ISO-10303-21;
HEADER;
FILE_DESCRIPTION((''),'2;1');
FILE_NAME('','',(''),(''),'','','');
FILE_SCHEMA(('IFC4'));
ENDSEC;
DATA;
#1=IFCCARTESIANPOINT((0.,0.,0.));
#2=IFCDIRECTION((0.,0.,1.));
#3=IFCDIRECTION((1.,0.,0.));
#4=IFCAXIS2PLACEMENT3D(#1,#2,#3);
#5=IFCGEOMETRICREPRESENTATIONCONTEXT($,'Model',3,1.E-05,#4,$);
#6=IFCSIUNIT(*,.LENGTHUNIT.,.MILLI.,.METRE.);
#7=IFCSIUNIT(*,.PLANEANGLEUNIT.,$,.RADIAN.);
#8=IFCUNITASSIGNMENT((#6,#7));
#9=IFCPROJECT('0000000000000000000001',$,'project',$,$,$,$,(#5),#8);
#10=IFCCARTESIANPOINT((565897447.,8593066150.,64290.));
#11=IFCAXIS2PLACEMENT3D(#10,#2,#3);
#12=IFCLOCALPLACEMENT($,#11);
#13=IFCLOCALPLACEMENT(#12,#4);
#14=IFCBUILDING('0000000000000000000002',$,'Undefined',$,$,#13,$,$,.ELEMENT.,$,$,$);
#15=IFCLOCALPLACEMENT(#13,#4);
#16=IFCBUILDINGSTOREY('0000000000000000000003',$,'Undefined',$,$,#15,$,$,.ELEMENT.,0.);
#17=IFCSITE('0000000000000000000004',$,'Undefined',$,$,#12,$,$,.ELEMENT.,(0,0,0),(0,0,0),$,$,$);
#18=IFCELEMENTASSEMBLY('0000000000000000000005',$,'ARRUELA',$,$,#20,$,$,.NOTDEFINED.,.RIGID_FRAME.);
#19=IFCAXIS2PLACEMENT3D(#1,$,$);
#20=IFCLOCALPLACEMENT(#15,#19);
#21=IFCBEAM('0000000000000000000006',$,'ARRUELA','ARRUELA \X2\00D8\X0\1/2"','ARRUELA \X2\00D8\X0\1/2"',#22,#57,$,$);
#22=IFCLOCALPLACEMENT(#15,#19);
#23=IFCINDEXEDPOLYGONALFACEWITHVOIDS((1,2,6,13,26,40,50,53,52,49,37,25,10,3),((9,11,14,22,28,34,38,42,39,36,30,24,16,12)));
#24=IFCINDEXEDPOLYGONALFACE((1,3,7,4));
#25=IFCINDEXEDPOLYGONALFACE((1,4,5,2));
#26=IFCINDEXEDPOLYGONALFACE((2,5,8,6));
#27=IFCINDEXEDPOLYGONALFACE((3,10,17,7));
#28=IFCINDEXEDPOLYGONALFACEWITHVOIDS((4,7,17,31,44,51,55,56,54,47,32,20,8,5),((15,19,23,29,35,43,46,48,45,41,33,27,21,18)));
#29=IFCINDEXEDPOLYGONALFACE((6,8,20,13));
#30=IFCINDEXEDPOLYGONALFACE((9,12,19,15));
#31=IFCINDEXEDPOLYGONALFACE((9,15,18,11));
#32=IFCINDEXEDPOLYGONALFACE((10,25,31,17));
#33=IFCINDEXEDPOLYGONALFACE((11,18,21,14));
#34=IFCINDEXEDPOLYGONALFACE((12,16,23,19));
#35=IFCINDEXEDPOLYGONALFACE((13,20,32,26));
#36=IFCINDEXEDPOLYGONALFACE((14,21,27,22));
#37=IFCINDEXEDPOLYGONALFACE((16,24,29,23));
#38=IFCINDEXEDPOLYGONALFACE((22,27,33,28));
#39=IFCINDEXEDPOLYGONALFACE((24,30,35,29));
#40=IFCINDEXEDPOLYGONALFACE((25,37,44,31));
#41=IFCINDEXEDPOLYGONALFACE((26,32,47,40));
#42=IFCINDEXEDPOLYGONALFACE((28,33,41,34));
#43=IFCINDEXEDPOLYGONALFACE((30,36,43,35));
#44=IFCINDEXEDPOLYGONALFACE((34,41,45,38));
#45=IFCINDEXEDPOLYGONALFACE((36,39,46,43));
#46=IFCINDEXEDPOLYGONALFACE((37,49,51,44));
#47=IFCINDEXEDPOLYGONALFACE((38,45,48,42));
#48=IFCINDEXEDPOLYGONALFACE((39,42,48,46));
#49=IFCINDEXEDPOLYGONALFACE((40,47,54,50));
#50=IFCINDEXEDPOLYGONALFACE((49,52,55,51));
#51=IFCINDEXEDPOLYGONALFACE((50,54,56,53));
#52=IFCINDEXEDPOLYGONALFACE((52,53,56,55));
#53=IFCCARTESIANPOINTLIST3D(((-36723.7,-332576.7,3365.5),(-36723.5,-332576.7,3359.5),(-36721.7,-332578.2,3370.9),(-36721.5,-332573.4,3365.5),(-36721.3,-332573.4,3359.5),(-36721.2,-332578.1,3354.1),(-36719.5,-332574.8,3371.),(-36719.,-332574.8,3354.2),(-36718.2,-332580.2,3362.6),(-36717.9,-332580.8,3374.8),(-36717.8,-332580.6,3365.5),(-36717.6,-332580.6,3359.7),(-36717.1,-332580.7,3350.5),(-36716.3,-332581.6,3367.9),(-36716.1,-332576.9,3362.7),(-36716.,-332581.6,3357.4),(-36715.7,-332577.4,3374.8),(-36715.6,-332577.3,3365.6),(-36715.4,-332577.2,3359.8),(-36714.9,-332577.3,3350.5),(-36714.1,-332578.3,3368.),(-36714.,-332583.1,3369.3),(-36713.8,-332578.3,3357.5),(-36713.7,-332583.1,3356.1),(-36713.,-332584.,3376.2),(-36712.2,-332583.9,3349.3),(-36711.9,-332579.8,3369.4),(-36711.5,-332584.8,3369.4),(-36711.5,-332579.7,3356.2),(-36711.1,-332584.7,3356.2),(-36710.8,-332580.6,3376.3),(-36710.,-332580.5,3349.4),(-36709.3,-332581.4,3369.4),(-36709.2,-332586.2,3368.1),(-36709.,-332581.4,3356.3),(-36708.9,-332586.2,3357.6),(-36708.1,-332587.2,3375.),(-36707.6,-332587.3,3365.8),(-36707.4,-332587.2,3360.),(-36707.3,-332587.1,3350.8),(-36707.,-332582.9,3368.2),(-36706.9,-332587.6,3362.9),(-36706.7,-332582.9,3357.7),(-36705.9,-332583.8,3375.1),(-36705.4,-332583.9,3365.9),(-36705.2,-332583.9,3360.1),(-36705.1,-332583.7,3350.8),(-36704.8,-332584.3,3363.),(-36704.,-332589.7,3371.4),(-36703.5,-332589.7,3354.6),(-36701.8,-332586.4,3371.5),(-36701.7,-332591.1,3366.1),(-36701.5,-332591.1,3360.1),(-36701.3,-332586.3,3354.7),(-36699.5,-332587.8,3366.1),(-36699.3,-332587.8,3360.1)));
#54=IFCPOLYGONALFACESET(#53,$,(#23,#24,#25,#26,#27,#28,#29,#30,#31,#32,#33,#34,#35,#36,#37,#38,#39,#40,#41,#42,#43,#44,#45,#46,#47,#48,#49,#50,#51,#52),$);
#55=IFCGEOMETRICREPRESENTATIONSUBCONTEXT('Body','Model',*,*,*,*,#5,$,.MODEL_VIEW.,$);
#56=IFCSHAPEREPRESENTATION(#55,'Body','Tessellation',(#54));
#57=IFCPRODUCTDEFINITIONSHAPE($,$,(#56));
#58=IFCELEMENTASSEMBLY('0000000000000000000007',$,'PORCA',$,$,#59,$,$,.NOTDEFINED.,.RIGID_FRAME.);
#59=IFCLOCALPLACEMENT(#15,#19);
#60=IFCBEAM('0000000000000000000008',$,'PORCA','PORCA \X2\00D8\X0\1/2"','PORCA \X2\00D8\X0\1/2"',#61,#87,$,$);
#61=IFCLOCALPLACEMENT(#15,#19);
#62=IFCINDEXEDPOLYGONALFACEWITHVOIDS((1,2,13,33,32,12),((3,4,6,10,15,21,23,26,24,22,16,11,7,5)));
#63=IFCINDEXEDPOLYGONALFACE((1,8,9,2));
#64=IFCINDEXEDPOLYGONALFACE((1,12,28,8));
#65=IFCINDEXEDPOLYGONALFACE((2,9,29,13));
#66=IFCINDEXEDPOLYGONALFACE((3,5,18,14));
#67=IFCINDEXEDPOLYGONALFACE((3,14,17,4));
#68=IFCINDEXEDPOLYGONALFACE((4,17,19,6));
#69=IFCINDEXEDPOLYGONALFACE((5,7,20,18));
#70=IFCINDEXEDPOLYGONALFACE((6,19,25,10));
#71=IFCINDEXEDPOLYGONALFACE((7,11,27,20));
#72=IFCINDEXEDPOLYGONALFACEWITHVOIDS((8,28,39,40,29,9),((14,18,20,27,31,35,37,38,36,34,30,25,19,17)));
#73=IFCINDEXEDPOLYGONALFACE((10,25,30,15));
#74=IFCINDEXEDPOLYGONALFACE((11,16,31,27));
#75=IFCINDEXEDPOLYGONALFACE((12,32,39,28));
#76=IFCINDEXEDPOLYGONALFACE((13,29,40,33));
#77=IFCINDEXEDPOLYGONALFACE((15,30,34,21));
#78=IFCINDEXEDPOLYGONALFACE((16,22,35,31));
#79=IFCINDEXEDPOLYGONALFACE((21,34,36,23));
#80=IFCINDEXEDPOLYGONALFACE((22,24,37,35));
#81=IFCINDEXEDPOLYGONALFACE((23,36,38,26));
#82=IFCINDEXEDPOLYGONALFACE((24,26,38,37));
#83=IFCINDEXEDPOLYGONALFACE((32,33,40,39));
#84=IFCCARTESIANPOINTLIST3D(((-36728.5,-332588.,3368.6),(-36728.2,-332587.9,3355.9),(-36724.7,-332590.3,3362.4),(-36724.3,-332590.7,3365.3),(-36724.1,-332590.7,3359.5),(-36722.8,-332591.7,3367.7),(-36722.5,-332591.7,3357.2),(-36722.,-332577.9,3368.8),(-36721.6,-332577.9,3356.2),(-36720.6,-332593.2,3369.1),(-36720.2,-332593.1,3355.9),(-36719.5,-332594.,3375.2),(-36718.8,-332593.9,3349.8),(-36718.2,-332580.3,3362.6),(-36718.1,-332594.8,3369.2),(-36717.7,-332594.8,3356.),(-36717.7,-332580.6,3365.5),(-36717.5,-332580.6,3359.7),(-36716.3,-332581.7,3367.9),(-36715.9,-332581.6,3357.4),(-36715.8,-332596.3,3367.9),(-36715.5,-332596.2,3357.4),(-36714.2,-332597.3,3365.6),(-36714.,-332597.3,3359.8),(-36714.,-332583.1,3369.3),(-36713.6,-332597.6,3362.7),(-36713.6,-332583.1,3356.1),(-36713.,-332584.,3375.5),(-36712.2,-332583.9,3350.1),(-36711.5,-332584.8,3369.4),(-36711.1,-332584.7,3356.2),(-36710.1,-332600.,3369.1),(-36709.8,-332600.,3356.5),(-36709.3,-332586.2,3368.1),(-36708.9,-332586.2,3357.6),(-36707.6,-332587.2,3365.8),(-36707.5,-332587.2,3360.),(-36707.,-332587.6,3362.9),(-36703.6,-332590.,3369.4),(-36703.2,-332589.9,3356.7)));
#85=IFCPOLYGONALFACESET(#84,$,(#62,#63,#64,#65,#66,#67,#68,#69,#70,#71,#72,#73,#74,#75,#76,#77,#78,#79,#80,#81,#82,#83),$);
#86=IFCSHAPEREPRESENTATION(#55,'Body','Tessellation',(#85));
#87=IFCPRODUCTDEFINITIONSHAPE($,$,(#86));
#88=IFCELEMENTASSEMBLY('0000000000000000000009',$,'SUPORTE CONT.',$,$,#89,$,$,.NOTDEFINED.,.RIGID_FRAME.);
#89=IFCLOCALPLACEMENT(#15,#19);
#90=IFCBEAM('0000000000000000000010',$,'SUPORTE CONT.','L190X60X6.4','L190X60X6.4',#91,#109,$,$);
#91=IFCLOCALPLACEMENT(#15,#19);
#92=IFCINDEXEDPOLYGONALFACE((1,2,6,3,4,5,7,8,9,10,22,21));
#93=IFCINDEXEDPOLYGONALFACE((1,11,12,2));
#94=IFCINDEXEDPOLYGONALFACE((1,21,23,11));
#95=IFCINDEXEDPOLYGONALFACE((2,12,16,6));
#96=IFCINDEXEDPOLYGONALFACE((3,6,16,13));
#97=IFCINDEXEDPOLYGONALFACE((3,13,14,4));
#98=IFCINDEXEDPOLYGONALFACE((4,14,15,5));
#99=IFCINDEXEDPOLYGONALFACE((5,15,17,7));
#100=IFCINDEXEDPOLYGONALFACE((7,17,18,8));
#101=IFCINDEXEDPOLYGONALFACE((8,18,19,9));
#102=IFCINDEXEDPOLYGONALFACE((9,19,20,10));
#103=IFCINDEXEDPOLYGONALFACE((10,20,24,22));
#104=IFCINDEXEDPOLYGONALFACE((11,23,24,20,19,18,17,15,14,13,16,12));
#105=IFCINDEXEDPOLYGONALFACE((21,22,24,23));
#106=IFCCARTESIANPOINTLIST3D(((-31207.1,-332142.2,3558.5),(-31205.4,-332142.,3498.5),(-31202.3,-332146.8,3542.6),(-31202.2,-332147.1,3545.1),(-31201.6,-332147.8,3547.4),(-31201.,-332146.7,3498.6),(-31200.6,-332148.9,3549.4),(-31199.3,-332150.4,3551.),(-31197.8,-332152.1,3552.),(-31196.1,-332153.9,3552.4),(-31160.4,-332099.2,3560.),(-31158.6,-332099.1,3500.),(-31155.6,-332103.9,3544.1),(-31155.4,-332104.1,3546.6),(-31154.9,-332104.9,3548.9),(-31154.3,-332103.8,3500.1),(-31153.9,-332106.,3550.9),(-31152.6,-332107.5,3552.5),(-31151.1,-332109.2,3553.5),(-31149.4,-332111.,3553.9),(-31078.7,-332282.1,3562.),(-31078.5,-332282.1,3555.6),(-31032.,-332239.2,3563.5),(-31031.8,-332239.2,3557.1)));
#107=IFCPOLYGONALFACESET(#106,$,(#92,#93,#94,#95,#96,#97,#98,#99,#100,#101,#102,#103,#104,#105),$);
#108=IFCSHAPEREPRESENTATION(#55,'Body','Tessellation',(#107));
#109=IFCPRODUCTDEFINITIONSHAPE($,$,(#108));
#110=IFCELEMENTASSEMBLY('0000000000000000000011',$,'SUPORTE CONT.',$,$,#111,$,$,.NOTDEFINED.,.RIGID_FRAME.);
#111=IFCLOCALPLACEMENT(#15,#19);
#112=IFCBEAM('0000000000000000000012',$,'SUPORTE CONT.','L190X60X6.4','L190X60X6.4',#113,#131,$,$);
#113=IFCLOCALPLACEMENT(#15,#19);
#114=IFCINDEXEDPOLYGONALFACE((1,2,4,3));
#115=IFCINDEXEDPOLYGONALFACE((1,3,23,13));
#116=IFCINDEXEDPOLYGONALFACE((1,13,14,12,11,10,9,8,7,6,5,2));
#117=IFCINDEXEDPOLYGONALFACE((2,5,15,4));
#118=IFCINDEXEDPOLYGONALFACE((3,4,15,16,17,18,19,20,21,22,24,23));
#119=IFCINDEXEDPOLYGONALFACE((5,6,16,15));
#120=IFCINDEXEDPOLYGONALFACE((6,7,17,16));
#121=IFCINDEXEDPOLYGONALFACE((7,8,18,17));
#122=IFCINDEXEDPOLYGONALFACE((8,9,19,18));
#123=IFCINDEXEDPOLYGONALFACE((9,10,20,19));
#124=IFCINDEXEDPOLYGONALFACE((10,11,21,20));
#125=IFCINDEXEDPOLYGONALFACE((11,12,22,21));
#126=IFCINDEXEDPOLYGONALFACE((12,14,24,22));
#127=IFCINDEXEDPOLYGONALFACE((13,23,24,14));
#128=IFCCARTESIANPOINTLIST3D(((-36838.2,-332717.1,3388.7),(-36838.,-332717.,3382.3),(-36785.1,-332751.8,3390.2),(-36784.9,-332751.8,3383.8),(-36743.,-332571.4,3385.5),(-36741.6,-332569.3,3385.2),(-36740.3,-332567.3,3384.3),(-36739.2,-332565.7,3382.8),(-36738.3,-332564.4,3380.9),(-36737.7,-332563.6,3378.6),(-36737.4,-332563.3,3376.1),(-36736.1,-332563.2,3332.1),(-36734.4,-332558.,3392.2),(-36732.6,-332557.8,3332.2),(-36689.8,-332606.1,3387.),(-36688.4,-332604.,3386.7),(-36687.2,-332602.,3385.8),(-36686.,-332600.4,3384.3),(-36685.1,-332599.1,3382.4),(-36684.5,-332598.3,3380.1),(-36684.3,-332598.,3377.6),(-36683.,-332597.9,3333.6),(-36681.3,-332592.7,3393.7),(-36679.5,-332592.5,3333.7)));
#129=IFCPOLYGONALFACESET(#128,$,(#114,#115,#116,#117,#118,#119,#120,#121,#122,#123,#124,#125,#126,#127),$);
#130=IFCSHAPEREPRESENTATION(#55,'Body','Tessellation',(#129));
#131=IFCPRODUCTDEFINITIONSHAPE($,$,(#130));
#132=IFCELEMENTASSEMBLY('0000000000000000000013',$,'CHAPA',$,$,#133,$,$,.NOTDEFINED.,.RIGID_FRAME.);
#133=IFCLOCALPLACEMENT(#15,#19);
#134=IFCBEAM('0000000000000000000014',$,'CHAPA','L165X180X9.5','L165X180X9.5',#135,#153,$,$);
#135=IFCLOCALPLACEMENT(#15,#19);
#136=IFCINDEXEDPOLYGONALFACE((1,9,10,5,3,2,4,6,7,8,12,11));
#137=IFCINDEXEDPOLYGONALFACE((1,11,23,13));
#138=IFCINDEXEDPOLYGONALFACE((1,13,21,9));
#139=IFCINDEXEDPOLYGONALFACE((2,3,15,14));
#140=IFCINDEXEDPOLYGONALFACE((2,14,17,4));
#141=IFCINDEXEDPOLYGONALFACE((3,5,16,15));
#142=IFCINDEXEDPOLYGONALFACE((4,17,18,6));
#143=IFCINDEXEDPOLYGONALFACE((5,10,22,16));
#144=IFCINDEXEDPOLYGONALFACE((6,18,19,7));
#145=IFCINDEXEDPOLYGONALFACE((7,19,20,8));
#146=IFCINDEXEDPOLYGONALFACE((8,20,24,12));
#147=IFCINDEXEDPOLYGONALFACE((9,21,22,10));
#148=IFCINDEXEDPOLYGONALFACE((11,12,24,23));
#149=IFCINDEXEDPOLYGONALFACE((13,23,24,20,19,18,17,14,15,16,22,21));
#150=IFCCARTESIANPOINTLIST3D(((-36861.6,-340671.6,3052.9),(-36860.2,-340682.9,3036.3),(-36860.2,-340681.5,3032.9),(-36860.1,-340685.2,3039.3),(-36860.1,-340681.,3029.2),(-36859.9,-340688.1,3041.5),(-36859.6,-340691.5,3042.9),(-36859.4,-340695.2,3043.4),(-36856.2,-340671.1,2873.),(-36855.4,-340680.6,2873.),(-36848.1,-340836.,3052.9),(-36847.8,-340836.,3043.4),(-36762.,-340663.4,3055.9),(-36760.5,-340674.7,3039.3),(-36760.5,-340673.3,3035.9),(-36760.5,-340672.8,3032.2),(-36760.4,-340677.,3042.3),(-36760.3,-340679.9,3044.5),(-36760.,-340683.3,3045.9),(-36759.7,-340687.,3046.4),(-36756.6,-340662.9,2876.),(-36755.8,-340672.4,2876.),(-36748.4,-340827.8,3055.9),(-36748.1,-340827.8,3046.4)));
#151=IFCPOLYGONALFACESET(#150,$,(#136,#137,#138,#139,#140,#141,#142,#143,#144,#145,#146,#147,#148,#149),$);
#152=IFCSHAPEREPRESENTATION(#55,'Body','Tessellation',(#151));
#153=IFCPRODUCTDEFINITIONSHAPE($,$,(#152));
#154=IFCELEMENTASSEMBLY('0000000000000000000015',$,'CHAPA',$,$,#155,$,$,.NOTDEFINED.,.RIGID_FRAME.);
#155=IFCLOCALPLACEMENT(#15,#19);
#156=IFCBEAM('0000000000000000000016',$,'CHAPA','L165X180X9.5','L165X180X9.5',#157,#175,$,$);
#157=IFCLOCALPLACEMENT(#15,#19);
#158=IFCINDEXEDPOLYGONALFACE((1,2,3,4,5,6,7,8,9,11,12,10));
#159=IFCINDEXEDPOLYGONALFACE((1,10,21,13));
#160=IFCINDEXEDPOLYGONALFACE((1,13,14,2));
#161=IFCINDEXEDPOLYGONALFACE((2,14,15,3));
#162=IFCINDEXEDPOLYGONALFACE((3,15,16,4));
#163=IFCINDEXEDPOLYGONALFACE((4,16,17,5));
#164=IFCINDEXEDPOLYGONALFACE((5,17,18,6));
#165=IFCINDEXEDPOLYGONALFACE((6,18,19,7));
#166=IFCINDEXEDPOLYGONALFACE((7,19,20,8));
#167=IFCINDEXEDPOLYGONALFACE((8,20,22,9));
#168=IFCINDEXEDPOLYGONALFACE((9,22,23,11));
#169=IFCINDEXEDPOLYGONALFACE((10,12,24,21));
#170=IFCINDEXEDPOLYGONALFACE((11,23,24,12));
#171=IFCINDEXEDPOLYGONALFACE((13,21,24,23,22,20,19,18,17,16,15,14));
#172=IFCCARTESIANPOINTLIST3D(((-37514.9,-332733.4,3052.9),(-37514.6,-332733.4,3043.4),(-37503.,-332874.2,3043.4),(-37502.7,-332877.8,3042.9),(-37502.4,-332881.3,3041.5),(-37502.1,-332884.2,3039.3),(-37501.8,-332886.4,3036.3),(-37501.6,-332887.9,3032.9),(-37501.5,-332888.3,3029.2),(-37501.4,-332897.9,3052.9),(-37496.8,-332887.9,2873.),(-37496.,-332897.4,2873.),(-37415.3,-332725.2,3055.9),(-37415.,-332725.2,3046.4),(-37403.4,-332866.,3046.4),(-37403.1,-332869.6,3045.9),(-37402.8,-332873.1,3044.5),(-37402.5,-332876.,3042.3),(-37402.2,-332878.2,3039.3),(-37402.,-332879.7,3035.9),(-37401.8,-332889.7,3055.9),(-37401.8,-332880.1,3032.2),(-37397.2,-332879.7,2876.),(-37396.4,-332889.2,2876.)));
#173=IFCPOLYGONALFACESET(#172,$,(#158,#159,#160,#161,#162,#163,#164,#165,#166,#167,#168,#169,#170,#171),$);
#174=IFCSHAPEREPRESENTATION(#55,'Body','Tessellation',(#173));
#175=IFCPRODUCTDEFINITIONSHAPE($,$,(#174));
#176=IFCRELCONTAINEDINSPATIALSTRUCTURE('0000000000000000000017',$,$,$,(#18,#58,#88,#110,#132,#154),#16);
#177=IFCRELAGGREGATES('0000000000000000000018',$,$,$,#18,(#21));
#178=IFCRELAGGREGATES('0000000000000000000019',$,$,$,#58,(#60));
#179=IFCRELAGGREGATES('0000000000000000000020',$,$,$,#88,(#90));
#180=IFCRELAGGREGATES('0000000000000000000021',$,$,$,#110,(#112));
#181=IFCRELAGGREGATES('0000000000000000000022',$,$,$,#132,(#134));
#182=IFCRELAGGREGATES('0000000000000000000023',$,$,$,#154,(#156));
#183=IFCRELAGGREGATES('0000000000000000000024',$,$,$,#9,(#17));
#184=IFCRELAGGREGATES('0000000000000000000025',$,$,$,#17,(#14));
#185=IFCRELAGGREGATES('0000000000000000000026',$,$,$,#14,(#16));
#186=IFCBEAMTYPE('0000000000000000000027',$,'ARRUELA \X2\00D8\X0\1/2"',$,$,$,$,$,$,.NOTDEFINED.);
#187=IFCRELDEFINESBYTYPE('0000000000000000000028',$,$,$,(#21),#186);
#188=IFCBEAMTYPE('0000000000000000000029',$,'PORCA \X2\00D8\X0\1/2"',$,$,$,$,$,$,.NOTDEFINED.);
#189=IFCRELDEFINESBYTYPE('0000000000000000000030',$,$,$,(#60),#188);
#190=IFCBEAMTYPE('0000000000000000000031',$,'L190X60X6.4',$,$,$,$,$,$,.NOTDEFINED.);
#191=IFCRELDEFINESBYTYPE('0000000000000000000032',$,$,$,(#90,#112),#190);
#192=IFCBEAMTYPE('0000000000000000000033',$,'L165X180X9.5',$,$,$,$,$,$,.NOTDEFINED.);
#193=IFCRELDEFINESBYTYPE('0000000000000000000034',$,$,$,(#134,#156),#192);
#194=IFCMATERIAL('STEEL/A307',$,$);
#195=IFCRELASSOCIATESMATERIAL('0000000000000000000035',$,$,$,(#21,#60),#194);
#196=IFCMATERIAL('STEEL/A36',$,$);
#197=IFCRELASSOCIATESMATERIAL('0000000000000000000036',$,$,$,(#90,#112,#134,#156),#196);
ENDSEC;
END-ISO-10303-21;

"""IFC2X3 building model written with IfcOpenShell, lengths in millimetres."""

from ifc_helpers import new_model, si_unit, frame, origin_with_axes, origin_2d_with_axis, place, context, subcontext, project, spatial, polyline, l_section, outline, extrude, material, type_object, element, aggregate, save


model = new_model("IFC2X3")

# Units and contexts
model_context = context("Model", 3, precision=1e-05, world=origin_with_axes())
body_context = subcontext(model_context, "Body", "Model", "MODEL_VIEW")
ifc_project = project(units=[si_unit("LENGTHUNIT", "METRE", prefix="MILLI"), si_unit("PLANEANGLEUNIT", "RADIAN")], contexts=[model_context])

# Site, building, storey
site_placement = place(None, frame((565897447.0, 8593066150.0, 64290.0), z_axis=(0.0, 0.0, 1.0), x_axis=(1.0, 0.0, 0.0)))
site = spatial("IfcSite", under=ifc_project, at=site_placement, Name="Undefined", CompositionType="ELEMENT", RefLatitude=(0, 0, 0), RefLongitude=(0, 0, 0))
building_placement = place(site_placement, origin_with_axes())
building = spatial("IfcBuilding", under=site, at=building_placement, Name="Undefined", CompositionType="ELEMENT")
storey_placement = place(building_placement, origin_with_axes())
storey = spatial("IfcBuildingStorey", under=building, at=storey_placement, Name="Undefined", CompositionType="ELEMENT", Elevation=0.0)

# Element assemblies, beams
ifc_material_1 = material(Name="STEEL/A36")
assembly_1_placement = place(storey_placement, origin_with_axes())
assembly_1 = element("IfcElementAssembly", 1, at=assembly_1_placement, inside=storey, Name="ARRUELA", AssemblyPlace="NOTDEFINED", PredefinedType="RIGID_FRAME")
ifc_material_2 = material(Name="STEEL/A307")
beam_type_1 = type_object("IfcBeamType", Name="ARRUELA Ø1/2\"", PredefinedType="NOTDEFINED")
beam_1_placement = place(assembly_1_placement, frame((-36712.6, -332583.9, 3362.8), z_axis=(-0.836984, 0.546715, -0.02368), x_axis=(0.546411, 0.837315, 0.018398)))
beam_1 = element("IfcBeam", 2, at=beam_1_placement, type_object=beam_type_1, material=ifc_material_2, Name="ARRUELA", Description="ARRUELA Ø1/2\"", ObjectType="ARRUELA Ø1/2\"", context=body_context, shape_type="SweptSolid", body=[
    extrude(outline(polyline([(-8.4, 10.5), (-3.0, 13.2), (3.0, 13.2), (8.4, 10.5), (12.2, 5.9), (13.5, 0.0), (12.2, -5.9), (8.4, -10.5), (3.0, -13.2), (-3.0, -13.2), (-8.4, -10.5), (-12.2, -5.9), (-13.5, 0.0), (-12.2, 5.9), (-8.4, 10.5)]), holes=[polyline([(5.3, 4.2), (2.9, 6.1), (0.0, 6.7), (-2.9, 6.1), (-5.3, 4.2), (-6.6, 1.5), (-6.6, -1.5), (-5.3, -4.2), (-2.9, -6.1), (0.0, -6.8), (2.9, -6.1), (5.3, -4.2), (6.6, -1.5), (6.6, 1.5), (5.3, 4.2)])]), frame((4.0, 0.0, 0.0), z_axis=(-1.0, 0.0, 0.0), x_axis=(0.0, -1.0, 0.0)), (0.0, 0.0, 1.0), 4.0),
])
aggregate(assembly_1, [beam_1])
assembly_2_placement = place(storey_placement, origin_with_axes())
assembly_2 = element("IfcElementAssembly", 3, at=assembly_2_placement, inside=storey, Name="PORCA", AssemblyPlace="NOTDEFINED", PredefinedType="RIGID_FRAME")
beam_type_2 = type_object("IfcBeamType", Name="PORCA Ø1/2\"", PredefinedType="NOTDEFINED")
beam_2_placement = place(assembly_2_placement, frame((-36719.2, -332594.0, 3362.5), z_axis=(-0.836984, 0.546715, -0.02368), x_axis=(0.546411, 0.837315, 0.018398)))
beam_2 = element("IfcBeam", 4, at=beam_2_placement, type_object=beam_type_2, material=ifc_material_2, Name="PORCA", Description="PORCA Ø1/2\"", ObjectType="PORCA Ø1/2\"", context=body_context, shape_type="SweptSolid", body=[
    extrude(outline(polyline([(-12.7, 0.0), (-6.3, 11.0), (6.3, 11.0), (12.7, 0.0), (6.3, -11.0), (-6.3, -11.0), (-12.7, 0.0)]), holes=[polyline([(5.3, 4.2), (2.9, 6.0), (0.0, 6.7), (-2.9, 6.0), (-5.3, 4.2), (-6.6, 1.5), (-6.6, -1.5), (-5.3, -4.2), (-2.9, -6.0), (0.0, -6.7), (2.9, -6.0), (5.3, -4.2), (6.6, -1.5), (6.6, 1.5), (5.3, 4.2)])]), frame((12.0, 0.0, 0.0), z_axis=(-1.0, 0.0, 0.0), x_axis=(0.0, -1.0, 0.0)), (0.0, 0.0, 1.0), 12.0),
])
aggregate(assembly_2, [beam_2])
assembly_3_placement = place(storey_placement, origin_with_axes())
assembly_3 = element("IfcElementAssembly", 5, at=assembly_3_placement, inside=storey, Name="SUPORTE CONT.", AssemblyPlace="NOTDEFINED", PredefinedType="RIGID_FRAME")
beam_type_3 = type_object("IfcBeamType", Name="L190X60X6.4", PredefinedType="NOTDEFINED")
beam_3_placement = place(assembly_3_placement, frame((-31142.0, -332212.1, 3530.2), z_axis=(0.675958, -0.736711, 0.018398), x_axis=(0.736334, 0.676203, 0.02368)))
beam_3 = element("IfcBeam", 6, at=beam_3_placement, type_object=beam_type_3, material=ifc_material_1, Name="SUPORTE CONT.", Description="L190X60X6.4", ObjectType="L190X60X6.4", context=body_context, shape_type="SweptSolid", body=[
    extrude(l_section(Depth=190.0, Width=60.0, Thickness=6.4, FilletRadius=9.6, at=origin_2d_with_axis()), frame((63.5, 0.0, 0.0), z_axis=(-1.0, 0.0, 0.0), x_axis=(0.0, -1.0, 0.0)), (0.0, 0.0, 1.0), 63.5),
])
aggregate(assembly_3, [beam_3])
assembly_4_placement = place(storey_placement, origin_with_axes())
assembly_4 = element("IfcElementAssembly", 7, at=assembly_4_placement, inside=storey, Name="SUPORTE CONT.", AssemblyPlace="NOTDEFINED", PredefinedType="RIGID_FRAME")
beam_4_placement = place(assembly_4_placement, frame((-36785.4, -332637.4, 3360.5), z_axis=(-0.546411, -0.837315, -0.018398), x_axis=(0.836984, -0.546715, 0.02368)))
beam_4 = element("IfcBeam", 8, at=beam_4_placement, type_object=beam_type_3, material=ifc_material_1, Name="SUPORTE CONT.", Description="L190X60X6.4", ObjectType="L190X60X6.4", context=body_context, shape_type="SweptSolid", body=[
    extrude(l_section(Depth=190.0, Width=60.0, Thickness=6.4, FilletRadius=9.6, at=origin_2d_with_axis()), frame((63.5, 0.0, 0.0), z_axis=(-1.0, 0.0, 0.0), x_axis=(0.0, -1.0, 0.0)), (0.0, 0.0, 1.0), 63.5),
])
assembly_5_placement = place(storey_placement, origin_with_axes())
assembly_5 = element("IfcElementAssembly", 9, at=assembly_5_placement, inside=storey, Name="CHAPA", AssemblyPlace="NOTDEFINED", PredefinedType="RIGID_FRAME")
beam_type_4 = type_object("IfcBeamType", Name="L165X180X9.5", PredefinedType="NOTDEFINED")
beam_5_placement = place(assembly_5_placement, frame((-36852.1, -340753.6, 2963.0), z_axis=(0.082025, -0.99663, 0.0), x_axis=(0.996182, 0.081989, 0.029987)))
beam_5 = element("IfcBeam", 10, at=beam_5_placement, type_object=beam_type_4, material=ifc_material_1, Name="CHAPA", Description="L165X180X9.5", ObjectType="L165X180X9.5", context=body_context, shape_type="SweptSolid", body=[
    extrude(l_section(Depth=165.0, Width=180.0, Thickness=9.5, FilletRadius=14.2, at=origin_2d_with_axis()), frame((100.0, 0.0, 0.0), z_axis=(-1.0, 0.0, 0.0), x_axis=(0.0, -1.0, 0.0)), (0.0, 0.0, 1.0), 100.0),
])
assembly_6_placement = place(storey_placement, origin_with_axes())
assembly_6 = element("IfcElementAssembly", 11, at=assembly_6_placement, inside=storey, Name="CHAPA", AssemblyPlace="NOTDEFINED", PredefinedType="RIGID_FRAME")
beam_6_placement = place(assembly_6_placement, frame((-37405.8, -332807.2, 2966.0), z_axis=(-0.082025, 0.99663, 0.0), x_axis=(-0.996182, -0.081989, -0.029987)))
beam_6 = element("IfcBeam", 12, at=beam_6_placement, type_object=beam_type_4, material=ifc_material_1, Name="CHAPA", Description="L165X180X9.5", ObjectType="L165X180X9.5", context=body_context, shape_type="SweptSolid", body=[
    extrude(l_section(Depth=165.0, Width=180.0, Thickness=9.5, FilletRadius=14.2, at=origin_2d_with_axis()), frame((100.0, 0.0, 0.0), z_axis=(-1.0, 0.0, 0.0), x_axis=(0.0, -1.0, 0.0)), (0.0, 0.0, 1.0), 100.0),
])

aggregate(assembly_4, [beam_4])
aggregate(assembly_5, [beam_5])
aggregate(assembly_6, [beam_6])

save(model, "model.ifc")
